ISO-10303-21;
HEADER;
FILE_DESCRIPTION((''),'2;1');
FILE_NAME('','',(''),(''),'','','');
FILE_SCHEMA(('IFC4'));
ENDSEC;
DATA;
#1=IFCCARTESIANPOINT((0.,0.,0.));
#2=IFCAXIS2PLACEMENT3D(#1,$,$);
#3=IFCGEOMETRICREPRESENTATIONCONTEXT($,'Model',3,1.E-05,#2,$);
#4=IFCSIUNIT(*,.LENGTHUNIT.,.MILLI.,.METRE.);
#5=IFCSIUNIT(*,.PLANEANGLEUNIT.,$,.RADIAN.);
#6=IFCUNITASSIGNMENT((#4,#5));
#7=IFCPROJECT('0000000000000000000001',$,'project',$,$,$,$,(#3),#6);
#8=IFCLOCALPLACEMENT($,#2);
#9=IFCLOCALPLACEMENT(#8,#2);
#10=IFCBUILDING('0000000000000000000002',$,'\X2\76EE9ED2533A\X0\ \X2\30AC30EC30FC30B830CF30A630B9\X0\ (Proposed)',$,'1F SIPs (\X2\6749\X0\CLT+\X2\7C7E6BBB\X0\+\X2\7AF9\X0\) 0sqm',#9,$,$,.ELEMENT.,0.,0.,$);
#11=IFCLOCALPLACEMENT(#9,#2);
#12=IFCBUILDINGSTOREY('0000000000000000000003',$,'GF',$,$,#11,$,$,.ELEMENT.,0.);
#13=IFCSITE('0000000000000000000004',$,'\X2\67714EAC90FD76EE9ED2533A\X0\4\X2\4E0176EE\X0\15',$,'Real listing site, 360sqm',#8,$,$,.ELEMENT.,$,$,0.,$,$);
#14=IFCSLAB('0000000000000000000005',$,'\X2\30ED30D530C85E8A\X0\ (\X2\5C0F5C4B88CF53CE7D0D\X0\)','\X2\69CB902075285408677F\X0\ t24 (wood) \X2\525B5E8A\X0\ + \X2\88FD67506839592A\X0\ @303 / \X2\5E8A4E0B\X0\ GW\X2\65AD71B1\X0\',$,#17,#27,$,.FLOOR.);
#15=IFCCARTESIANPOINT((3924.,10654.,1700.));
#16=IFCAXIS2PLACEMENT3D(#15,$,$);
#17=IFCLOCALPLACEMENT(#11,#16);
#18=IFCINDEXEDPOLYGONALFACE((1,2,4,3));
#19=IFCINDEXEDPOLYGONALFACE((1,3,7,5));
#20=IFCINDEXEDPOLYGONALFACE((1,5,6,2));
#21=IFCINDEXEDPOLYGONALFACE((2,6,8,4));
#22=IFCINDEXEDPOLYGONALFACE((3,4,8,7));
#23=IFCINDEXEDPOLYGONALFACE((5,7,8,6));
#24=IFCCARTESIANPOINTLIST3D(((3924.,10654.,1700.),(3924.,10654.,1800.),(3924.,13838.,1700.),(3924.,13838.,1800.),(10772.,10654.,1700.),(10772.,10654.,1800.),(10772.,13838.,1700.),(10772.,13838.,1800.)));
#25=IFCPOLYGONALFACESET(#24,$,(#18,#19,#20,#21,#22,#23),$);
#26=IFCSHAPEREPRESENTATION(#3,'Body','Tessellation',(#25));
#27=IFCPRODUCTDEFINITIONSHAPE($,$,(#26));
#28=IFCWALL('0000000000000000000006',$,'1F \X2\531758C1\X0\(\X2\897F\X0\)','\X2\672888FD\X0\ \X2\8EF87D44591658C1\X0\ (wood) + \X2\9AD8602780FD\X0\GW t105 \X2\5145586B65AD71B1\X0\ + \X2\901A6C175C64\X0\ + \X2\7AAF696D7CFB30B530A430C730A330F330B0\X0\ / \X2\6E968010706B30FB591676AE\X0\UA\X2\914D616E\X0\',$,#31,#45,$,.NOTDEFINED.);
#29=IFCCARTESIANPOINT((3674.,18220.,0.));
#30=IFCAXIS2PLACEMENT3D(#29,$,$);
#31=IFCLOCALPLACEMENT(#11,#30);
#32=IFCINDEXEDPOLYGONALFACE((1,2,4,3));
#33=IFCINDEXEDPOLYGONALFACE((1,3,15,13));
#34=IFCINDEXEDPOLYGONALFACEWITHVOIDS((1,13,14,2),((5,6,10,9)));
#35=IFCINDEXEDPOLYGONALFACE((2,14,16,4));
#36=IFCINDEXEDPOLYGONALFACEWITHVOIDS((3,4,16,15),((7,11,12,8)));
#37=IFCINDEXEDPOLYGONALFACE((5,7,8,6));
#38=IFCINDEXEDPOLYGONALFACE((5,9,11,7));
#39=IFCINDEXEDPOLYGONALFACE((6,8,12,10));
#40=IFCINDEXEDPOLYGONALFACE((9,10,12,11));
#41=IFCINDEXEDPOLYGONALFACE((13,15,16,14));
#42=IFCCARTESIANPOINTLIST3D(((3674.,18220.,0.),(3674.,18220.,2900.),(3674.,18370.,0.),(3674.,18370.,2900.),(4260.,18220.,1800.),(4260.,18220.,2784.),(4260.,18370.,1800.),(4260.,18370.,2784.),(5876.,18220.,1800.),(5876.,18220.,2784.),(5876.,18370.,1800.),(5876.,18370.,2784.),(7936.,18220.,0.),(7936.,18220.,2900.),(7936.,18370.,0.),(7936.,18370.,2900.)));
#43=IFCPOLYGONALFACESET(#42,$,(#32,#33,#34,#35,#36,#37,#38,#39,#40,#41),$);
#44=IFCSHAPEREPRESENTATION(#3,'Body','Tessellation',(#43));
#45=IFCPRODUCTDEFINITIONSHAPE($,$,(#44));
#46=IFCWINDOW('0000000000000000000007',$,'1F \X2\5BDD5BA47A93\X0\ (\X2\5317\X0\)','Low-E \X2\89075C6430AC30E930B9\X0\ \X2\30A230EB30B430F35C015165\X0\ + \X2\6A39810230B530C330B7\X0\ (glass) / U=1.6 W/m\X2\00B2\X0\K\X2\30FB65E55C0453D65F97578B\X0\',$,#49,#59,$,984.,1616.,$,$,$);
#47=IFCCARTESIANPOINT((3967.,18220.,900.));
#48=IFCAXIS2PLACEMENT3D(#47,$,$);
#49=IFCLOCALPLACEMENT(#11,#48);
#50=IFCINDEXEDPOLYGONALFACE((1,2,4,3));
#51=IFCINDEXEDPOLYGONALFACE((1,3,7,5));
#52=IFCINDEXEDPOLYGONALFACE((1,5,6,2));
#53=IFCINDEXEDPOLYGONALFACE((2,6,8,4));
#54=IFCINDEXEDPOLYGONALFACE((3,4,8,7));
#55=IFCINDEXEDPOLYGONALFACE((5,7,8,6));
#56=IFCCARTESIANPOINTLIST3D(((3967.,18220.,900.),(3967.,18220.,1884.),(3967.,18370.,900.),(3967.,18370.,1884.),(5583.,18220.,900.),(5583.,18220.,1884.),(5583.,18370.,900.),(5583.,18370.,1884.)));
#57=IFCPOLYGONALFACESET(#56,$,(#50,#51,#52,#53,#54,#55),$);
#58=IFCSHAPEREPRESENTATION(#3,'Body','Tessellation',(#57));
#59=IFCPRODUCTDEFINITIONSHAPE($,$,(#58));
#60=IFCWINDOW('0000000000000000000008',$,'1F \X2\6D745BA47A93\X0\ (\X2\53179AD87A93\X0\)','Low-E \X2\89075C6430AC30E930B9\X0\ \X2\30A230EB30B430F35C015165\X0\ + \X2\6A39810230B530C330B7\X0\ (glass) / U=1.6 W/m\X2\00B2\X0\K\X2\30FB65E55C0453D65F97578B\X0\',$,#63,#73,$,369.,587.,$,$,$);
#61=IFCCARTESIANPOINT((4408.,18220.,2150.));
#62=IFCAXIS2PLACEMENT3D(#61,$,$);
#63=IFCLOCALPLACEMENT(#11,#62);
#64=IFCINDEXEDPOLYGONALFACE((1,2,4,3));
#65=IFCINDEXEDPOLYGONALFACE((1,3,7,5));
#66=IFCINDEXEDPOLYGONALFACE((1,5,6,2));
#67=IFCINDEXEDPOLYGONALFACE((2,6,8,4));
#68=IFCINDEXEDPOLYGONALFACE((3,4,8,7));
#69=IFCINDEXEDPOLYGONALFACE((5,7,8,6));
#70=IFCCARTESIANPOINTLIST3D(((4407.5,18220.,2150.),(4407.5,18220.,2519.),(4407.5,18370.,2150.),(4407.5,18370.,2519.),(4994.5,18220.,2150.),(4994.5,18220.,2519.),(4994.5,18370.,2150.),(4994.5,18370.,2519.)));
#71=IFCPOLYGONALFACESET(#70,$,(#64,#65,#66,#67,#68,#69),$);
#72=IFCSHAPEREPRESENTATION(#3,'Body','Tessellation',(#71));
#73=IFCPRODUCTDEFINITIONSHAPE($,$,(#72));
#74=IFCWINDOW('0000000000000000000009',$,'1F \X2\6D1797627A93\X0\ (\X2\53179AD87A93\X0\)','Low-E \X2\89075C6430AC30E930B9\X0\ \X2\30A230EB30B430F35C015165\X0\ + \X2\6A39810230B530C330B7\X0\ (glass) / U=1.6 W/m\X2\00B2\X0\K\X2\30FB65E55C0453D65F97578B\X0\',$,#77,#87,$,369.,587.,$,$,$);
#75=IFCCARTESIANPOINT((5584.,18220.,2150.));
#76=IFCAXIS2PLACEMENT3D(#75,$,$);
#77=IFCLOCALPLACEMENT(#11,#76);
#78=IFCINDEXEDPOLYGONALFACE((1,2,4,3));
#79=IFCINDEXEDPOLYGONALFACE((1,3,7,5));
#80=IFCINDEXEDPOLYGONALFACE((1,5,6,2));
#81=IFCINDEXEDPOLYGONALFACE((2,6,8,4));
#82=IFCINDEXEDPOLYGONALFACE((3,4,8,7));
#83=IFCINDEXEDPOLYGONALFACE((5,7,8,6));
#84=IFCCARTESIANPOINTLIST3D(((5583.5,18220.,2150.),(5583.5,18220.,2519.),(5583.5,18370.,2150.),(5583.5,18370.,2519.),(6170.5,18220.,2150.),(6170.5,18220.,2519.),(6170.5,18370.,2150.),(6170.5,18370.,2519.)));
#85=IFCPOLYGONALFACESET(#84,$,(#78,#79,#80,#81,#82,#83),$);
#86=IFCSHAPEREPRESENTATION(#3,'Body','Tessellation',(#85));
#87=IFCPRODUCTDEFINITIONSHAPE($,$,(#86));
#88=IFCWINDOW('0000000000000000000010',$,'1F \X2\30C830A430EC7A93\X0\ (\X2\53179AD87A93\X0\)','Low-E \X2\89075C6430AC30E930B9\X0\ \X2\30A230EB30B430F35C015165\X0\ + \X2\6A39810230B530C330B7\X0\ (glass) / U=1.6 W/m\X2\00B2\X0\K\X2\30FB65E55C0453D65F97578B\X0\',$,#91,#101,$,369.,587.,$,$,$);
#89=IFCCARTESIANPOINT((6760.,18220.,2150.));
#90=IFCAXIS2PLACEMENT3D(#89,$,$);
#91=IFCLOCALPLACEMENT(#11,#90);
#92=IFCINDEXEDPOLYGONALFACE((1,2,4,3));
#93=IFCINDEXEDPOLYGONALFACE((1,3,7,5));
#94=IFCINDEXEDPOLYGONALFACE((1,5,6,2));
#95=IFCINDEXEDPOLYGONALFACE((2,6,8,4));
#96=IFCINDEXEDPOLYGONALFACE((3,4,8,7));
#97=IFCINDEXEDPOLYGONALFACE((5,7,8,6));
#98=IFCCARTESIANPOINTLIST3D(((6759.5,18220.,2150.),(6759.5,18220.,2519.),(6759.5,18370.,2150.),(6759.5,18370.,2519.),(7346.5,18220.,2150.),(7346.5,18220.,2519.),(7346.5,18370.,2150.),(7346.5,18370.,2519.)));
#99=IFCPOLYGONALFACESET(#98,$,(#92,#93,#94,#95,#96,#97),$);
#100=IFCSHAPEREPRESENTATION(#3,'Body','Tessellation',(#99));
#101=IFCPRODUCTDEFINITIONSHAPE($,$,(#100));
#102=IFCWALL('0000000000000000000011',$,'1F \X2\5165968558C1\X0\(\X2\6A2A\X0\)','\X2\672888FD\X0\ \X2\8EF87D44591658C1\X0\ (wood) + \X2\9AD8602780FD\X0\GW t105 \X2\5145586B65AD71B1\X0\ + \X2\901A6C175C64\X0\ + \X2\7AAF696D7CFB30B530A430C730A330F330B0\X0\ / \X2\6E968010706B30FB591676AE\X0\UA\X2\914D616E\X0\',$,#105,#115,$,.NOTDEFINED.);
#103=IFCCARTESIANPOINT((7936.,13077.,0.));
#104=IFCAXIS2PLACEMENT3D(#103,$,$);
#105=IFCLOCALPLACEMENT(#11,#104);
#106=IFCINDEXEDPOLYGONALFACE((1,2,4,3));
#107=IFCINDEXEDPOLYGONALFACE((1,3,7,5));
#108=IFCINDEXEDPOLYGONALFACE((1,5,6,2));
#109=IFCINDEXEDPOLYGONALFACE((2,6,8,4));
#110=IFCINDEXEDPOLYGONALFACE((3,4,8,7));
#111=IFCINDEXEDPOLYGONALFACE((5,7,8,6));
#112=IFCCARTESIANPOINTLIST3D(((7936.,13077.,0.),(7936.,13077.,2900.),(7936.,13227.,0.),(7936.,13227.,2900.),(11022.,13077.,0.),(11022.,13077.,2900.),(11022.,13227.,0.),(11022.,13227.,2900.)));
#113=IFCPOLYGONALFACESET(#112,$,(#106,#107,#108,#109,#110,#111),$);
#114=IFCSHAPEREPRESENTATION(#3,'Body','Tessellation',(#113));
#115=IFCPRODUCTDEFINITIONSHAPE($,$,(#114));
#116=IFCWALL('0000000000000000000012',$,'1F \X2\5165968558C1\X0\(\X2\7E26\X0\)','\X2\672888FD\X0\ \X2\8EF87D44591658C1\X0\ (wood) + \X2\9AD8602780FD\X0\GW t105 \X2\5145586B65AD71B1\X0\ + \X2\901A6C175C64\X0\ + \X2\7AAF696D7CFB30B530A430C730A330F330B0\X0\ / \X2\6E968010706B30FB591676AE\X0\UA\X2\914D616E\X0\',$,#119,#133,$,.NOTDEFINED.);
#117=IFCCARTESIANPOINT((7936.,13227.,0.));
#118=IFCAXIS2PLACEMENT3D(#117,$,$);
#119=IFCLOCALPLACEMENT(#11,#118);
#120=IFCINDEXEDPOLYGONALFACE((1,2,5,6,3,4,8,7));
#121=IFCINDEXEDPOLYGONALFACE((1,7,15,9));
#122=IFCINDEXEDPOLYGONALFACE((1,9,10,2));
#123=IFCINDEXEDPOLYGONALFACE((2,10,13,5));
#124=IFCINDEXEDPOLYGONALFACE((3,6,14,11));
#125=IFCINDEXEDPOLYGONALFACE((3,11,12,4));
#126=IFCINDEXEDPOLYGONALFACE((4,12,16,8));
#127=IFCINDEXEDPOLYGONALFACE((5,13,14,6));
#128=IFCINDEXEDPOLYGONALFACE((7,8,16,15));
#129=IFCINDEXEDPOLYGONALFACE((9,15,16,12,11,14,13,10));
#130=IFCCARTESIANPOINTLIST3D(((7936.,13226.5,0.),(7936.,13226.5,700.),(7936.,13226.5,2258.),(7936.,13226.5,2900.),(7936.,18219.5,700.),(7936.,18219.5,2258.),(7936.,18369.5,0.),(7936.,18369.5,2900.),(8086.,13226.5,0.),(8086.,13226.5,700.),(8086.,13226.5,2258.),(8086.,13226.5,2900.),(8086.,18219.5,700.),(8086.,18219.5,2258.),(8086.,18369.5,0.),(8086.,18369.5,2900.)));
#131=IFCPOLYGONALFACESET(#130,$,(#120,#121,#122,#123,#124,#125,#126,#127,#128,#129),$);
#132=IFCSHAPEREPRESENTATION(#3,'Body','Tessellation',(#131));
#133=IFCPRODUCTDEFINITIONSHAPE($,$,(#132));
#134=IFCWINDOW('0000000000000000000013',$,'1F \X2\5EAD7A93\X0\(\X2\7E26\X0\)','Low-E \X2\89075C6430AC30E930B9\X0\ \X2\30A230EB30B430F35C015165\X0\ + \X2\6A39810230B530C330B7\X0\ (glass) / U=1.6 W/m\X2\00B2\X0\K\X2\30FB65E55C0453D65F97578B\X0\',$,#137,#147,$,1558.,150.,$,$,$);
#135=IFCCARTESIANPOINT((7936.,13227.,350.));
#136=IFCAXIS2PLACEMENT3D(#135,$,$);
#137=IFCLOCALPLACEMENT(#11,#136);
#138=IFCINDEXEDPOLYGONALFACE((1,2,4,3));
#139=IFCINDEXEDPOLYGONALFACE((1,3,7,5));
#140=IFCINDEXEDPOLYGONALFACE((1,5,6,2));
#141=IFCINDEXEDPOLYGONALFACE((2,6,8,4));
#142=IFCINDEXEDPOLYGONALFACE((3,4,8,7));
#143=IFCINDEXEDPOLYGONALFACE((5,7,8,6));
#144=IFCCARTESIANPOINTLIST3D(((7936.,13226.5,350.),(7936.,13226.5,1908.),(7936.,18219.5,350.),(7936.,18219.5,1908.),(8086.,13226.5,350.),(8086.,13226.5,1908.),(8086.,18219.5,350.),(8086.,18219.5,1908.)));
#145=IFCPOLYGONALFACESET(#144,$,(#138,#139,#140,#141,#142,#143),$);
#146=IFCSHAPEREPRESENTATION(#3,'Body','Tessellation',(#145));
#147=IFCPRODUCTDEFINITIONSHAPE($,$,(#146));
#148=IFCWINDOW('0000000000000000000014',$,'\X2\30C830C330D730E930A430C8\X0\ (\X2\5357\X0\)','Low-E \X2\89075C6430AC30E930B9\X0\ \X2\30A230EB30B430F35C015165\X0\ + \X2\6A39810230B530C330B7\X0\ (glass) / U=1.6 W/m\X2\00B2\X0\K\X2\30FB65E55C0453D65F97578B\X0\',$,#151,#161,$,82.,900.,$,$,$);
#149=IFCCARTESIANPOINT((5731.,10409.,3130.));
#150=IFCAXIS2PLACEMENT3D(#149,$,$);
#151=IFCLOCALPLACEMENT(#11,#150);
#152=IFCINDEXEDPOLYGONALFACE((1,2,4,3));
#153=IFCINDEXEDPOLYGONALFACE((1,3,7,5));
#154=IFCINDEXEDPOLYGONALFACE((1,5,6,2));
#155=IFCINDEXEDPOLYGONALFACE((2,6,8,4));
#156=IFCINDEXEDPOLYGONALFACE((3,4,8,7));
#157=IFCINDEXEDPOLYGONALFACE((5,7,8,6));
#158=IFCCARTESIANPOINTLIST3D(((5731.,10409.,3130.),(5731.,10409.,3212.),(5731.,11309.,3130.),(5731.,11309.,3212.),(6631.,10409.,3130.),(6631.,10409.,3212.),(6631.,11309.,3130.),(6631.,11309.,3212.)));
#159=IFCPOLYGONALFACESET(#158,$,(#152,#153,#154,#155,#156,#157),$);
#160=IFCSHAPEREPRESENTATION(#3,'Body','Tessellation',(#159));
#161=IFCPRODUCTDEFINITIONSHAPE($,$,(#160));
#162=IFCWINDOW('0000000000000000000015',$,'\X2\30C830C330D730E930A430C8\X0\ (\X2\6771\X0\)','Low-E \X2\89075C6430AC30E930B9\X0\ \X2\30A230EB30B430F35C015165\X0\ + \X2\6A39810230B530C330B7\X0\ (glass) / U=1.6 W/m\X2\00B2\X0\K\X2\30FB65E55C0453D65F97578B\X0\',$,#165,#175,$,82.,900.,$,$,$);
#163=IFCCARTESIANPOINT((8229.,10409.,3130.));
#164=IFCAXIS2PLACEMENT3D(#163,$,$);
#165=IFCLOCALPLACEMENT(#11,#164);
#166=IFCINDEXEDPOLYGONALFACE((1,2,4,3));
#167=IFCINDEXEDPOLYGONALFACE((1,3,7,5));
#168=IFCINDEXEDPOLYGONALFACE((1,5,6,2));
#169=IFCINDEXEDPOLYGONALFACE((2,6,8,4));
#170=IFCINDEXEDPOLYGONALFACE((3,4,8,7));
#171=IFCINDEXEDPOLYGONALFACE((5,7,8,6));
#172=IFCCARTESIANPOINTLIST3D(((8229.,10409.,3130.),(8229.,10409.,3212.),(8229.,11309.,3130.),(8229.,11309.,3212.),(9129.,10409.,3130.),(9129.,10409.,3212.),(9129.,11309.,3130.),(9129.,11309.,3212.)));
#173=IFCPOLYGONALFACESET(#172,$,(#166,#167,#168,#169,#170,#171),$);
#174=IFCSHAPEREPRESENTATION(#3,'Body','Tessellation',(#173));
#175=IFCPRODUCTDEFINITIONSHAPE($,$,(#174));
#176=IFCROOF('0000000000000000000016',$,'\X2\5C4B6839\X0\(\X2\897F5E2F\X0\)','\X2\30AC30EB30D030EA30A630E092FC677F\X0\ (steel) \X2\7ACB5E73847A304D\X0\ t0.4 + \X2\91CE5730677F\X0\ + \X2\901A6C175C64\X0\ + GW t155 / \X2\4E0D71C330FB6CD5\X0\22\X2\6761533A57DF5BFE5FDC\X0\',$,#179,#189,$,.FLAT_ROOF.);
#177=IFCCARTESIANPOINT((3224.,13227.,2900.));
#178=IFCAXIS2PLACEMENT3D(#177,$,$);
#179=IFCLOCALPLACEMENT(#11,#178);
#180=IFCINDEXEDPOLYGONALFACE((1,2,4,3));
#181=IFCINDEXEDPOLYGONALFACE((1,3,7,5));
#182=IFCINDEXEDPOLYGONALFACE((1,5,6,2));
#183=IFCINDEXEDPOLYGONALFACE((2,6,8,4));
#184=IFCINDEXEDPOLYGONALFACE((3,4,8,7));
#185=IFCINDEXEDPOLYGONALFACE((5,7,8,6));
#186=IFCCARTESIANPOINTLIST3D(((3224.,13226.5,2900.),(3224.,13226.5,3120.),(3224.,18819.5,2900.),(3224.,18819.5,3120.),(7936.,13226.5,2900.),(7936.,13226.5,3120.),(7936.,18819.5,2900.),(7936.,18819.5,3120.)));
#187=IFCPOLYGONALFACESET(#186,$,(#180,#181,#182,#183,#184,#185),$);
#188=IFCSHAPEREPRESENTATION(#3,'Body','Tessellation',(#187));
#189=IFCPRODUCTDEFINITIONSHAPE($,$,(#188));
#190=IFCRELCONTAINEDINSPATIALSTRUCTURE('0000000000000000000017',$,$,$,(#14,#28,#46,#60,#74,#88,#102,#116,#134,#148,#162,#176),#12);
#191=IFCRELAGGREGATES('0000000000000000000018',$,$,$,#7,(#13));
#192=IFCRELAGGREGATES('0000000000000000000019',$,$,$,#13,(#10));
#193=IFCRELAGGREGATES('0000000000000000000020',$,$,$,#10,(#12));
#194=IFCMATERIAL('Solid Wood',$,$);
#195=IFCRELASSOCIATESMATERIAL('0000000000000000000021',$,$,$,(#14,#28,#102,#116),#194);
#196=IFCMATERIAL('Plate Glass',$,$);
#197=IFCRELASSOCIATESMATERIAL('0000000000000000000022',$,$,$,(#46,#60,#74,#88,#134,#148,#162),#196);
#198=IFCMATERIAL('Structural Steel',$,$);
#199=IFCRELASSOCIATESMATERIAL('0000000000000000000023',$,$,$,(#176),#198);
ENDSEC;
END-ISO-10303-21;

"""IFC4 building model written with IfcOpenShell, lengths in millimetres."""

from ifc_helpers import new_model, si_unit, frame, frame_2d, origin, place, context, project, spatial, rectangle, extrude, material, element, fill, save


model = new_model("IFC4")

# Units and contexts
model_context = context("Model", 3, precision=1e-05, world=origin())
ifc_project = project(units=[si_unit("LENGTHUNIT", "METRE", prefix="MILLI"), si_unit("PLANEANGLEUNIT", "RADIAN")], contexts=[model_context])

# Site, building, storey
site_placement = place(None, origin())
site = spatial("IfcSite", under=ifc_project, at=site_placement, Name="東京都目黒区4丁目15", ObjectType="Real listing site, 360sqm", CompositionType="ELEMENT", RefElevation=0.0)
building_placement = place(site_placement, origin())
building = spatial("IfcBuilding", under=site, at=building_placement, Name="目黒区 ガレージハウス (Proposed)", ObjectType="1F SIPs (杉CLT+籾殻+竹) 0sqm", CompositionType="ELEMENT", ElevationOfRefHeight=0.0, ElevationOfTerrain=0.0)
storey_placement = place(building_placement, origin())
storey = spatial("IfcBuildingStorey", under=building, at=storey_placement, Name="GF", CompositionType="ELEMENT", Elevation=0.0)

# Slab
ifc_material_1 = material(Name="Solid Wood")
slab_1_placement = place(storey_placement, frame((3924.0, 10654.0, 1700.0)))
element("IfcSlab", 1, at=slab_1_placement, inside=storey, material=ifc_material_1, Name="ロフト床 (小屋裏収納)", Description="構造用合板 t24 (wood) 剛床 + 製材根太 @303 / 床下 GW断熱", PredefinedType="FLOOR", context=model_context, shape_type="SweptSolid", body=[
    extrude(rectangle(XDim=6848.0, YDim=3184.0, at=frame_2d((3424.0, 1592.0))), frame((3924.0, 10654.0, 1700.0)), (0.0, 0.0, 1.0), 100.0),
])

# Wall, openings, windows
wall_1_placement = place(storey_placement, frame((3674.0, 18220.0, 0.0)))
wall_1 = element("IfcWall", 2, at=wall_1_placement, inside=storey, material=ifc_material_1, Name="1F 北壁(西)", Description="木製 軸組外壁 (wood) + 高性能GW t105 充填断熱 + 通気層 + 窯業系サイディング / 準耐火・外皮UA配慮", PredefinedType="NOTDEFINED", context=model_context, shape_type="SweptSolid", body=[
    extrude(rectangle(XDim=4262.0, YDim=150.0, at=frame_2d((2131.0, 75.0))), frame((3674.0, 18220.0, 0.0)), (0.0, 0.0, 1.0), 2900.0),
])
opening_1_placement = place(storey_placement, frame((3967.0, 18220.0, 900.0)))
opening_1 = element("IfcOpeningElement", 3, at=opening_1_placement, cuts=wall_1, PredefinedType="NOTDEFINED", context=model_context, shape_type="SweptSolid", body=[
    extrude(rectangle(XDim=1616.0, YDim=150.0, at=frame_2d((808.0, 75.0))), frame((3967.0, 18220.0, 900.0)), (0.0, 0.0, 1.0), 984.0),
])
opening_2_placement = place(storey_placement, frame((4408.0, 18220.0, 2150.0)))
opening_2 = element("IfcOpeningElement", 4, at=opening_2_placement, cuts=wall_1, PredefinedType="NOTDEFINED", context=model_context, shape_type="SweptSolid", body=[
    extrude(rectangle(XDim=587.0, YDim=150.0, at=frame_2d((293.0, 75.0))), frame((4408.0, 18220.0, 2150.0)), (0.0, 0.0, 1.0), 369.0),
])
opening_3_placement = place(storey_placement, frame((5584.0, 18220.0, 2150.0)))
opening_3 = element("IfcOpeningElement", 5, at=opening_3_placement, cuts=wall_1, PredefinedType="NOTDEFINED", context=model_context, shape_type="SweptSolid", body=[
    extrude(rectangle(XDim=587.0, YDim=150.0, at=frame_2d((293.0, 75.0))), frame((5584.0, 18220.0, 2150.0)), (0.0, 0.0, 1.0), 369.0),
])
opening_4_placement = place(storey_placement, frame((6760.0, 18220.0, 2150.0)))
opening_4 = element("IfcOpeningElement", 6, at=opening_4_placement, cuts=wall_1, PredefinedType="NOTDEFINED", context=model_context, shape_type="SweptSolid", body=[
    extrude(rectangle(XDim=587.0, YDim=150.0, at=frame_2d((293.0, 75.0))), frame((6760.0, 18220.0, 2150.0)), (0.0, 0.0, 1.0), 369.0),
])
ifc_material_2 = material(Name="Plate Glass")
window_1_placement = place(storey_placement, frame((3967.0, 18220.0, 900.0)))
window_1 = element("IfcWindow", 7, at=window_1_placement, inside=storey, material=ifc_material_2, Name="1F 寝室窓 (北)", Description="Low-E 複層ガラス アルゴン封入 + 樹脂サッシ (glass) / U=1.6 W/m²K・日射取得型", OverallHeight=984.0, OverallWidth=1616.0, context=model_context, shape_type="SweptSolid", body=[
    extrude(rectangle(XDim=1616.0, YDim=150.0, at=frame_2d((808.0, 75.0))), frame((3967.0, 18220.0, 900.0)), (0.0, 0.0, 1.0), 984.0),
])
fill(opening_1, window_1)
window_2_placement = place(storey_placement, frame((4408.0, 18220.0, 2150.0)))
window_2 = element("IfcWindow", 8, at=window_2_placement, inside=storey, material=ifc_material_2, Name="1F 浴室窓 (北高窓)", Description="Low-E 複層ガラス アルゴン封入 + 樹脂サッシ (glass) / U=1.6 W/m²K・日射取得型", OverallHeight=369.0, OverallWidth=587.0, context=model_context, shape_type="SweptSolid", body=[
    extrude(rectangle(XDim=587.0, YDim=150.0, at=frame_2d((293.0, 75.0))), frame((4408.0, 18220.0, 2150.0)), (0.0, 0.0, 1.0), 369.0),
])
fill(opening_2, window_2)
window_3_placement = place(storey_placement, frame((5584.0, 18220.0, 2150.0)))
window_3 = element("IfcWindow", 9, at=window_3_placement, inside=storey, material=ifc_material_2, Name="1F 洗面窓 (北高窓)", Description="Low-E 複層ガラス アルゴン封入 + 樹脂サッシ (glass) / U=1.6 W/m²K・日射取得型", OverallHeight=369.0, OverallWidth=587.0, context=model_context, shape_type="SweptSolid", body=[
    extrude(rectangle(XDim=587.0, YDim=150.0, at=frame_2d((293.0, 75.0))), frame((5584.0, 18220.0, 2150.0)), (0.0, 0.0, 1.0), 369.0),
])
fill(opening_3, window_3)
window_4_placement = place(storey_placement, frame((6760.0, 18220.0, 2150.0)))
window_4 = element("IfcWindow", 10, at=window_4_placement, inside=storey, material=ifc_material_2, Name="1F トイレ窓 (北高窓)", Description="Low-E 複層ガラス アルゴン封入 + 樹脂サッシ (glass) / U=1.6 W/m²K・日射取得型", OverallHeight=369.0, OverallWidth=587.0, context=model_context, shape_type="SweptSolid", body=[
    extrude(rectangle(XDim=587.0, YDim=150.0, at=frame_2d((293.0, 75.0))), frame((6760.0, 18220.0, 2150.0)), (0.0, 0.0, 1.0), 369.0),
])
fill(opening_4, window_4)

# Wall
wall_2_placement = place(storey_placement, frame((7936.0, 13077.0, 0.0)))
element("IfcWall", 11, at=wall_2_placement, inside=storey, material=ifc_material_1, Name="1F 入隅壁(横)", Description="木製 軸組外壁 (wood) + 高性能GW t105 充填断熱 + 通気層 + 窯業系サイディング / 準耐火・外皮UA配慮", PredefinedType="NOTDEFINED", context=model_context, shape_type="SweptSolid", body=[
    extrude(rectangle(XDim=3086.0, YDim=150.0, at=frame_2d((1543.0, 75.0))), frame((7936.0, 13077.0, 0.0)), (0.0, 0.0, 1.0), 2900.0),
])

# Wall, opening, window
wall_3_placement = place(storey_placement, frame((7936.0, 13227.0, 0.0)))
wall_3 = element("IfcWall", 12, at=wall_3_placement, inside=storey, material=ifc_material_1, Name="1F 入隅壁(縦)", Description="木製 軸組外壁 (wood) + 高性能GW t105 充填断熱 + 通気層 + 窯業系サイディング / 準耐火・外皮UA配慮", PredefinedType="NOTDEFINED", context=model_context, shape_type="SweptSolid", body=[
    extrude(rectangle(XDim=150.0, YDim=5143.0, at=frame_2d((75.0, 2571.0))), frame((7936.0, 13227.0, 0.0)), (0.0, 0.0, 1.0), 2900.0),
])
opening_5_placement = place(storey_placement, frame((7936.0, 13227.0, 350.0)))
opening_5 = element("IfcOpeningElement", 13, at=opening_5_placement, cuts=wall_3, PredefinedType="NOTDEFINED", context=model_context, shape_type="SweptSolid", body=[
    extrude(rectangle(XDim=150.0, YDim=4993.0, at=frame_2d((75.0, 2496.0))), frame((7936.0, 13227.0, 350.0)), (0.0, 0.0, 1.0), 1558.0),
])
window_5_placement = place(storey_placement, frame((7936.0, 13227.0, 350.0)))
window_5 = element("IfcWindow", 14, at=window_5_placement, inside=storey, material=ifc_material_2, Name="1F 庭窓(縦)", Description="Low-E 複層ガラス アルゴン封入 + 樹脂サッシ (glass) / U=1.6 W/m²K・日射取得型", OverallHeight=1558.0, OverallWidth=150.0, context=model_context, shape_type="SweptSolid", body=[
    extrude(rectangle(XDim=150.0, YDim=4993.0, at=frame_2d((75.0, 2496.0))), frame((7936.0, 13227.0, 350.0)), (0.0, 0.0, 1.0), 1558.0),
])
fill(opening_5, window_5)

# Windows
window_6_placement = place(storey_placement, frame((5731.0, 10409.0, 3130.0)))
element("IfcWindow", 15, at=window_6_placement, inside=storey, material=ifc_material_2, Name="トップライト (南)", Description="Low-E 複層ガラス アルゴン封入 + 樹脂サッシ (glass) / U=1.6 W/m²K・日射取得型", OverallHeight=82.0, OverallWidth=900.0, context=model_context, shape_type="SweptSolid", body=[
    extrude(rectangle(XDim=900.0, YDim=900.0, at=frame_2d((450.0, 450.0))), frame((5731.0, 10409.0, 3130.0)), (0.0, 0.0, 1.0), 82.0),
])
window_7_placement = place(storey_placement, frame((8229.0, 10409.0, 3130.0)))
element("IfcWindow", 16, at=window_7_placement, inside=storey, material=ifc_material_2, Name="トップライト (東)", Description="Low-E 複層ガラス アルゴン封入 + 樹脂サッシ (glass) / U=1.6 W/m²K・日射取得型", OverallHeight=82.0, OverallWidth=900.0, context=model_context, shape_type="SweptSolid", body=[
    extrude(rectangle(XDim=900.0, YDim=900.0, at=frame_2d((450.0, 450.0))), frame((8229.0, 10409.0, 3130.0)), (0.0, 0.0, 1.0), 82.0),
])

# Roof
ifc_material_3 = material(Name="Structural Steel")
roof_placement = place(storey_placement, frame((3224.0, 13227.0, 2900.0)))
element("IfcRoof", 17, at=roof_placement, inside=storey, material=ifc_material_3, Name="屋根(西帯)", Description="ガルバリウム鋼板 (steel) 立平葺き t0.4 + 野地板 + 通気層 + GW t155 / 不燃・法22条区域対応", PredefinedType="FLAT_ROOF", context=model_context, shape_type="SweptSolid", body=[
    extrude(rectangle(XDim=4712.0, YDim=5593.0, at=frame_2d((2356.0, 2796.0))), frame((3224.0, 13227.0, 2900.0)), (0.0, 0.0, 1.0), 220.0),
])

save(model, "model.ifc")
